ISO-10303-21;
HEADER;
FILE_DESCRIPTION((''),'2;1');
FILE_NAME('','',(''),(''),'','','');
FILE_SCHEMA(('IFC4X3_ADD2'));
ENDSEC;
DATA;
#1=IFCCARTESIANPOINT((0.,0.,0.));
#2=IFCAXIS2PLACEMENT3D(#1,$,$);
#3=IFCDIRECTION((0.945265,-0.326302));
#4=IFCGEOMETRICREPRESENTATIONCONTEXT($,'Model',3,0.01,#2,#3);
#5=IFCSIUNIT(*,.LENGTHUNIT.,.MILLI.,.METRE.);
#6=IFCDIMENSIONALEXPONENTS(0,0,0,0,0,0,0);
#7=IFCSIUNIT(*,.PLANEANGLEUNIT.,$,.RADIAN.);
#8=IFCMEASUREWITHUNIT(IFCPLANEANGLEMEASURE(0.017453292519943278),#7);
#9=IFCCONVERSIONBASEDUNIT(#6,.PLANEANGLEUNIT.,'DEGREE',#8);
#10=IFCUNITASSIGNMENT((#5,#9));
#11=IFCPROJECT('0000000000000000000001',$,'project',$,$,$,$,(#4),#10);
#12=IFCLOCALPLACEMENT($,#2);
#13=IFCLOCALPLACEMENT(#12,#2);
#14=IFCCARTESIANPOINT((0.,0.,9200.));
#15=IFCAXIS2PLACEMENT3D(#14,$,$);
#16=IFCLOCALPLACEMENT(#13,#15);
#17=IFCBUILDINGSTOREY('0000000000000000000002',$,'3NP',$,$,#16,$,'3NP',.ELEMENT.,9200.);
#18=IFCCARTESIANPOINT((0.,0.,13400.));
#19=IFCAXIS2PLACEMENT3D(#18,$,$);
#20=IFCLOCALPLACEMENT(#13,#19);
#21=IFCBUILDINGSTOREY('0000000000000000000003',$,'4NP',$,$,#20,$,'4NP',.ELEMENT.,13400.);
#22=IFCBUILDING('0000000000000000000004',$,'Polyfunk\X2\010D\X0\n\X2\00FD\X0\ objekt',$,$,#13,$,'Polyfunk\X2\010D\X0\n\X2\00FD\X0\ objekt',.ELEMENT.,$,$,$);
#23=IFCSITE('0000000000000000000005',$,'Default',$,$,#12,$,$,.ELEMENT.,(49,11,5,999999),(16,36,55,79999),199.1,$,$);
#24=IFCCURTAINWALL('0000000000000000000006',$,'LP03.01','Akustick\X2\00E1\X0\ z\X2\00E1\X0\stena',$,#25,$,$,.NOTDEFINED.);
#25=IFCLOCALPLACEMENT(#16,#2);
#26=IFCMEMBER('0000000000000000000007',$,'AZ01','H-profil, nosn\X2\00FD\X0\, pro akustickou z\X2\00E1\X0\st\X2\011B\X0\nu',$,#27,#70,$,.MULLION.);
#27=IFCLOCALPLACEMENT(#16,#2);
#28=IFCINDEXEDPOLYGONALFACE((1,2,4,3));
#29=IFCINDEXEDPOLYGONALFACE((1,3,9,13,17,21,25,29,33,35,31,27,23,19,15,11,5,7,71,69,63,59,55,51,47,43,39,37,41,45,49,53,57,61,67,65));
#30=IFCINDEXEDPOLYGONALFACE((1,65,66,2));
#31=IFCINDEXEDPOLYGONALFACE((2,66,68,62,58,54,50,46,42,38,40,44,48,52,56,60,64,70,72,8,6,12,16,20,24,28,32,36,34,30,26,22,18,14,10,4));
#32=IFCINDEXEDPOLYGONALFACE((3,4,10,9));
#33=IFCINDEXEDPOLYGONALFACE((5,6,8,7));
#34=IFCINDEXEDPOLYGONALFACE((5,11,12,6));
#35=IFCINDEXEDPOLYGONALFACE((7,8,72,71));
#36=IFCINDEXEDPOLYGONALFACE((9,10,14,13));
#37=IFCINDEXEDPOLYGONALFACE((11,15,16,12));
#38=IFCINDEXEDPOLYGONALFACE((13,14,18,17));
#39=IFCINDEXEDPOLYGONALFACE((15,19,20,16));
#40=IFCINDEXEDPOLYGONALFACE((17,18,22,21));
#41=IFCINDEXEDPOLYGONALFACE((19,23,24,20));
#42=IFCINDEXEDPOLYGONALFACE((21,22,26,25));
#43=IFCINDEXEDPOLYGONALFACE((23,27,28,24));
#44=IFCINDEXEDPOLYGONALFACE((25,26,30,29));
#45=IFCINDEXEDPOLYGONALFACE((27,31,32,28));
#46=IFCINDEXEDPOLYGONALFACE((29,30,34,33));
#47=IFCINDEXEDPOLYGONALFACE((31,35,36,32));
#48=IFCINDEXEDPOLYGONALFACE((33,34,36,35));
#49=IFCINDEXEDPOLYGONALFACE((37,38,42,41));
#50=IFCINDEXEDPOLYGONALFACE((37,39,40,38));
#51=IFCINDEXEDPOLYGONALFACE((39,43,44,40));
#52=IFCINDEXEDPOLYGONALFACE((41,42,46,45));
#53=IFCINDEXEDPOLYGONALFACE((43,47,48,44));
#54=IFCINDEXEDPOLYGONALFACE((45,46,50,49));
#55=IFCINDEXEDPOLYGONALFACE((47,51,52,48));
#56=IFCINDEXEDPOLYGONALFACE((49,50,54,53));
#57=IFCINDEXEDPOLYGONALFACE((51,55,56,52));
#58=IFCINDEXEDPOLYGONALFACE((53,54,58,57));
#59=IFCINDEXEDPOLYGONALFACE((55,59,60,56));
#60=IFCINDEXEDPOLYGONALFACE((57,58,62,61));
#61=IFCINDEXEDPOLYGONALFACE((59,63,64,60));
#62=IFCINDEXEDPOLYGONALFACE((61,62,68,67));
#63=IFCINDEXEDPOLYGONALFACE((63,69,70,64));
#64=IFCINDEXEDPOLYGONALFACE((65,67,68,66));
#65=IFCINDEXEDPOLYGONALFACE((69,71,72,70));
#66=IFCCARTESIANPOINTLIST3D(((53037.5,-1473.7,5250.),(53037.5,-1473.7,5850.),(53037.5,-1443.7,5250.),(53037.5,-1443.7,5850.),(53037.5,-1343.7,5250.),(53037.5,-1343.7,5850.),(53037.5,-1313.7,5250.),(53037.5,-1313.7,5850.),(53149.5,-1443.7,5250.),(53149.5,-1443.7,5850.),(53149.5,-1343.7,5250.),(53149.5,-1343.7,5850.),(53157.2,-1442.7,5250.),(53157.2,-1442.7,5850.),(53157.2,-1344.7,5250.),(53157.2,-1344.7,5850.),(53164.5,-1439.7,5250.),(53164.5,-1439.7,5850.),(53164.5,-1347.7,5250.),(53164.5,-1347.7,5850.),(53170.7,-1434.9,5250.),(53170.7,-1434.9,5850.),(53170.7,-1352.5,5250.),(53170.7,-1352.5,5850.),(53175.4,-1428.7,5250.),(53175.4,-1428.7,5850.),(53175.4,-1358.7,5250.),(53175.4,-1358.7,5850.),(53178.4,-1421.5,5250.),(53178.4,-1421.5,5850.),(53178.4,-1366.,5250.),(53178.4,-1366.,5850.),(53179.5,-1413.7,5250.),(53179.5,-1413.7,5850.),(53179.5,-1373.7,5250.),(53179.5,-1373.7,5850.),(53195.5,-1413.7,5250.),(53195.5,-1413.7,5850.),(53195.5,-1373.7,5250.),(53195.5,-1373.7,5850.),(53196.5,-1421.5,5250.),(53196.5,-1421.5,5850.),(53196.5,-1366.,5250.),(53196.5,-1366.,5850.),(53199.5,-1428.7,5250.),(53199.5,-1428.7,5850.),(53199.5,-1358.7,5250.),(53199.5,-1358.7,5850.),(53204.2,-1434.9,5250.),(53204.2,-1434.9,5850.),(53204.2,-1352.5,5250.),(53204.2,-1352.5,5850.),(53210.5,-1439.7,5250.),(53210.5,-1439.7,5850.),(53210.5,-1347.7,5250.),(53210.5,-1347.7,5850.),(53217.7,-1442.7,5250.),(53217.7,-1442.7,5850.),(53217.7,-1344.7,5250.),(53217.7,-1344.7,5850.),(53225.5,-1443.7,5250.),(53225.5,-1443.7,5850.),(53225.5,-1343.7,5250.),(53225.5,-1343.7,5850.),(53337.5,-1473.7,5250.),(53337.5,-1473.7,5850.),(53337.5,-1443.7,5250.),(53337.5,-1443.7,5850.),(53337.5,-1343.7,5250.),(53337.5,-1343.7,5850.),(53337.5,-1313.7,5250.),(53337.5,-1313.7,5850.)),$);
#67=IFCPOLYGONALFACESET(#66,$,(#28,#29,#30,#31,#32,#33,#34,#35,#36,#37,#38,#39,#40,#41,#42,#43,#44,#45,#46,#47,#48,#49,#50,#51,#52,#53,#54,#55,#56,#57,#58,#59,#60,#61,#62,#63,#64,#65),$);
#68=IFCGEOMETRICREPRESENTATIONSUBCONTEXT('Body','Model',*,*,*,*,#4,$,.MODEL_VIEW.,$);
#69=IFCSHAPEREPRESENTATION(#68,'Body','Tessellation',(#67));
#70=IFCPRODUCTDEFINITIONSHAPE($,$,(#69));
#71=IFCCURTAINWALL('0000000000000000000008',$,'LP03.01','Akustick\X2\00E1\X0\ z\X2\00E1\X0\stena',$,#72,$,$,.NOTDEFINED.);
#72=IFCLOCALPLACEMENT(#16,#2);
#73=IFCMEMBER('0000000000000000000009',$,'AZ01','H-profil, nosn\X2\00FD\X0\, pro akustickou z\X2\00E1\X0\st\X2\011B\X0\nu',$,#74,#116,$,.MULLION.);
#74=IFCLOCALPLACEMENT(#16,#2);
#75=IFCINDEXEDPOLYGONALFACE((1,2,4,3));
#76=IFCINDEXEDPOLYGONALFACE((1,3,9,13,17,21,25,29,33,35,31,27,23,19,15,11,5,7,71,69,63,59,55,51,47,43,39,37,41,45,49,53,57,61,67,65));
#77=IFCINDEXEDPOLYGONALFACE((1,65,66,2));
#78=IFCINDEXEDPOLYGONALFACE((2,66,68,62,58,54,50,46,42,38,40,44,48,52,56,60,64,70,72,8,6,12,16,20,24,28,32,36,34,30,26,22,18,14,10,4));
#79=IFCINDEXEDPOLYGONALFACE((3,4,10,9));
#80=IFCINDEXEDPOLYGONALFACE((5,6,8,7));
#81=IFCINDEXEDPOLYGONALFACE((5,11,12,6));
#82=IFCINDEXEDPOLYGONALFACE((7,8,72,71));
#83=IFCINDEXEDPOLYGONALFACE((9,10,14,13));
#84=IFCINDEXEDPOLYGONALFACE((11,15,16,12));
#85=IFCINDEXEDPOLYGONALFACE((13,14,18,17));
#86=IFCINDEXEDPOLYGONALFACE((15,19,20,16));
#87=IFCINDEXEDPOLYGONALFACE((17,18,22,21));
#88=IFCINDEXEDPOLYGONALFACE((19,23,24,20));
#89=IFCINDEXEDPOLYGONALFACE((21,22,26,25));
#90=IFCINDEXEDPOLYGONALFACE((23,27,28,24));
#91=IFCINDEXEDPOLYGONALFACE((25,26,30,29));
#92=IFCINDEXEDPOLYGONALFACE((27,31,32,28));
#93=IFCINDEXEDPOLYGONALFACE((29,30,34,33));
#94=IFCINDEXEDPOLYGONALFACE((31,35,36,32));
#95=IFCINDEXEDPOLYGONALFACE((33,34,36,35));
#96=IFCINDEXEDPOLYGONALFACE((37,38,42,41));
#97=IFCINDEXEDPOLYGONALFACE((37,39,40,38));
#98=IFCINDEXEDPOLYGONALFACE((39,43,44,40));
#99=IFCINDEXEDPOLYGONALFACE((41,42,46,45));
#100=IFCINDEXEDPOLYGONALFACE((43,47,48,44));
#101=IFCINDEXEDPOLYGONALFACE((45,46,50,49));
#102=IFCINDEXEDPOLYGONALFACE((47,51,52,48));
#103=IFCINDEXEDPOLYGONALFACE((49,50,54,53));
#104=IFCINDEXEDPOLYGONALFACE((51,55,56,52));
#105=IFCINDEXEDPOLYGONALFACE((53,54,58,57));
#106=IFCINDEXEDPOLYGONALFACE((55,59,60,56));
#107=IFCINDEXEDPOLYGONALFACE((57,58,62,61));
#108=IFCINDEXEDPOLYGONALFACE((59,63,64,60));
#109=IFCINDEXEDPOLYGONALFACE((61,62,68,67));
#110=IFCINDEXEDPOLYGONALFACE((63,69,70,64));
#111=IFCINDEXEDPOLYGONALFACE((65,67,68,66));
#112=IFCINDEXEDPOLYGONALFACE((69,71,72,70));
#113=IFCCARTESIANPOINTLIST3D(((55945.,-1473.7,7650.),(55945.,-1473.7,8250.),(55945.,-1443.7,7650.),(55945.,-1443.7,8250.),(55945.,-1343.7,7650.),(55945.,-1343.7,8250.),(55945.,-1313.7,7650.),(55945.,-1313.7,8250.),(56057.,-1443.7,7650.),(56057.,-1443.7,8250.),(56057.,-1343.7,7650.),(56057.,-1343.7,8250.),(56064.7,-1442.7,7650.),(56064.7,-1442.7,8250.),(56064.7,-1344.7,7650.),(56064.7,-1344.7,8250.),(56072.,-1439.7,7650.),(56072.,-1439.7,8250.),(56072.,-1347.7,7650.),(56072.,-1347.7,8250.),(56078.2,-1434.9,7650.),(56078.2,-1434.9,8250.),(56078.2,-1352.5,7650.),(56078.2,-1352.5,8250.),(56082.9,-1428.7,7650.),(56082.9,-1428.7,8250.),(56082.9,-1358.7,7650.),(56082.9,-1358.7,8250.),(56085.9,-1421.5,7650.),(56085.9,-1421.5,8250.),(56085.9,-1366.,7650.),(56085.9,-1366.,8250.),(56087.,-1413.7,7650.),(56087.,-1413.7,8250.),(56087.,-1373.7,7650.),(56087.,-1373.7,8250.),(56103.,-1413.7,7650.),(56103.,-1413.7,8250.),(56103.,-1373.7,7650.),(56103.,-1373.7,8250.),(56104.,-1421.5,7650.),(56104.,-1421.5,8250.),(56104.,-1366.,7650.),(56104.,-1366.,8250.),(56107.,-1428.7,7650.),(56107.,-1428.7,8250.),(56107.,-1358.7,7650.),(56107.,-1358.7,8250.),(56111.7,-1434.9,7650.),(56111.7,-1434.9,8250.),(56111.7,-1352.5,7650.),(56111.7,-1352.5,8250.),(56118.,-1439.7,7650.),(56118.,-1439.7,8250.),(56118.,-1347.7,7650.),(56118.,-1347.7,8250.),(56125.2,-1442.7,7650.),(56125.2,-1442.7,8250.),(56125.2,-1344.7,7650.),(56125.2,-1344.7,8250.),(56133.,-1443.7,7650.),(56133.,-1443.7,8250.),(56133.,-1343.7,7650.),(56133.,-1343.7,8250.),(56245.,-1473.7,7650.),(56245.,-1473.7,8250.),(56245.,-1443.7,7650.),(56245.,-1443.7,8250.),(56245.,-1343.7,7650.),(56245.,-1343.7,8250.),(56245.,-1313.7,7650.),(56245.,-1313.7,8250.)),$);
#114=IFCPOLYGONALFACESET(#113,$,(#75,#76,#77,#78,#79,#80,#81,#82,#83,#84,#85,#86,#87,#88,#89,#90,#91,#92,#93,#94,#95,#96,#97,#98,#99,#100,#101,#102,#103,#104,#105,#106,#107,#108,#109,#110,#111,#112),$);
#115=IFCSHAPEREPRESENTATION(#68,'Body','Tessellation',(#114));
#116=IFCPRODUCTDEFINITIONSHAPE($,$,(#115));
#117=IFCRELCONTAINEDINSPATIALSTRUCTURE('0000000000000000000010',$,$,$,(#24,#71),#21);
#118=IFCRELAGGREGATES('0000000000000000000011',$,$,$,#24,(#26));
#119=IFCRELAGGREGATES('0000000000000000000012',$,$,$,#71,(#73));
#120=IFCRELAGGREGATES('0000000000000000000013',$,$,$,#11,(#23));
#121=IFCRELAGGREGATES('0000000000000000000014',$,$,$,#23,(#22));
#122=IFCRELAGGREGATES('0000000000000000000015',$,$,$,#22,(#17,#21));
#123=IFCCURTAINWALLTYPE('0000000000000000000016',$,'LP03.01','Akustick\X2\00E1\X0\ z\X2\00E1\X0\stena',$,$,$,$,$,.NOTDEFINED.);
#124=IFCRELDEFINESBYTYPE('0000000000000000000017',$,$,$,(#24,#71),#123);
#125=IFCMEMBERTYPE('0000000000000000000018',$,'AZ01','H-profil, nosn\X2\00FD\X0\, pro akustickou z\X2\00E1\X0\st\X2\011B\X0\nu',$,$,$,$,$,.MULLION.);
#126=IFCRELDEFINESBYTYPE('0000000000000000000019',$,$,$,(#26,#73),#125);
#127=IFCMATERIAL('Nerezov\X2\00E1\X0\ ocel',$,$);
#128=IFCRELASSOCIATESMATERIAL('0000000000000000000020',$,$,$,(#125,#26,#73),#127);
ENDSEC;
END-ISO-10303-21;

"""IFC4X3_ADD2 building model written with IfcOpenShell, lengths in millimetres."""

from ifc_helpers import new_model, entity, si_unit, converted_unit, direction, frame, frame_2d, origin, place, context, subcontext, project, spatial, polyline, circle_curve, parameter, trimmed, segment, composite_curve, outline, extrude, source, transform, mapped, material, material_profile, profile_set, profile_usage, type_object, element, aggregate, save


model = new_model("IFC4X3_ADD2")

# Units and contexts
model_context = context("Model", 3, precision=0.01, world=origin(), true_north=direction((0.945265, -0.326302)))
body_context = subcontext(model_context, "Body", "Model", "MODEL_VIEW")
ifc_project = project(units=[si_unit("LENGTHUNIT", "METRE", prefix="MILLI"), converted_unit("PLANEANGLEUNIT", "DEGREE", entity("IfcPlaneAngleMeasure", 0.017453292519943278), si_unit("PLANEANGLEUNIT", "RADIAN"), dimensions=[0, 0, 0, 0, 0, 0, 0])], contexts=[model_context])

# Site, building, storey
site_placement = place(None, origin())
site = spatial("IfcSite", under=ifc_project, at=site_placement, Name="Default", CompositionType="ELEMENT", RefLatitude=(49, 11, 5, 999999), RefLongitude=(16, 36, 55, 79999), RefElevation=199.1)
building_placement = place(site_placement, origin())
building = spatial("IfcBuilding", under=site, at=building_placement, Name="Polyfunkčný objekt", LongName="Polyfunkčný objekt", CompositionType="ELEMENT")
storey_1_placement = place(building_placement, frame((0.0, 0.0, 9200.0)))
storey_1 = spatial("IfcBuildingStorey", under=building, at=storey_1_placement, Name="3NP", LongName="3NP", CompositionType="ELEMENT", Elevation=9200.0)

# Shared definitions
storey_2_placement = place(building_placement, frame((0.0, 0.0, 13400.0)))
storey_2 = spatial("IfcBuildingStorey", under=building, at=storey_2_placement, Name="4NP", LongName="4NP", CompositionType="ELEMENT", Elevation=13400.0)

# Curtain walls, members
curtain_wall_type_1 = type_object("IfcCurtainWallType", Name="LP03.01", Description="Akustická zástena", PredefinedType="NOTDEFINED")
curtain_wall_1_placement = place(storey_2_placement, frame((0.0, 0.0, -13400.0)))
curtain_wall_1 = element("IfcCurtainWall", 1, at=curtain_wall_1_placement, inside=storey_2, type_object=curtain_wall_type_1, Name="LP03.01", Description="Akustická zástena", PredefinedType="NOTDEFINED")
ifc_material_1 = material(Name="Nerezová ocel")
ifc_material_profile_1 = material_profile(ifc_material_1, outline(composite_curve([segment(polyline([(50.0, -150.0), (80.0, -150.0)]), True, "CONTINUOUS"), segment(polyline([(80.0, -150.0), (80.0, 150.0)]), True, "CONTINUOUS"), segment(polyline([(80.0, 150.0), (50.0, 150.0)]), True, "CONTINUOUS"), segment(polyline([(50.0, 150.0), (50.0, 38.0)]), True, "CONTINUOUS"), segment(trimmed(circle_curve(frame_2d((20.0, 38.0), x_axis=(0.0, 1.0)), 30.0), [parameter(180.0)], [parameter(270.0)], True, "PARAMETER"), False, "CONTINUOUS"), segment(polyline([(20.0, 8.0), (-20.0, 8.0)]), True, "CONTINUOUS"), segment(trimmed(circle_curve(frame_2d((-20.0, 38.0), x_axis=(0.0, 1.0)), 30.0), [parameter(90.0)], [parameter(180.0)], True, "PARAMETER"), False, "CONTINUOUS"), segment(polyline([(-50.0, 38.0), (-50.0, 150.0)]), True, "CONTINUOUS"), segment(polyline([(-50.0, 150.0), (-80.0, 150.0)]), True, "CONTINUOUS"), segment(polyline([(-80.0, 150.0), (-80.0, -150.0)]), True, "CONTINUOUS"), segment(polyline([(-80.0, -150.0), (-50.0, -150.0)]), True, "CONTINUOUS"), segment(polyline([(-50.0, -150.0), (-50.0, -38.0)]), True, "CONTINUOUS"), segment(trimmed(circle_curve(frame_2d((-20.0, -38.0), x_axis=(0.0, 1.0)), 30.0), [parameter(0.0)], [parameter(90.0)], True, "PARAMETER"), False, "CONTINUOUS"), segment(polyline([(-20.0, -8.0), (20.0, -8.0)]), True, "CONTINUOUS"), segment(trimmed(circle_curve(frame_2d((20.0, -38.0), x_axis=(0.0, 1.0)), 30.0), [parameter(270.0)], [parameter(0.0)], True, "PARAMETER"), False, "CONTINUOUS"), segment(polyline([(50.0, -38.0), (50.0, -150.0)]), True, "CONTINUOUS")], self_intersect=False)), Name="Profil zástena")
ifc_profile_set_1 = profile_set([ifc_material_profile_1], Name="Profil zástena")
ifc_profile_usage_1 = profile_usage(ifc_profile_set_1)
member_type_1 = type_object("IfcMemberType", Name="AZ01", Description="H-profil, nosný, pro akustickou zástěnu", PredefinedType="MULLION", material=ifc_profile_set_1)
shared_shape_1 = source(origin(), body_context, "Body", "SweptSolid", [
    extrude(outline(composite_curve([segment(polyline([(50.0, -150.0), (80.0, -150.0)]), True, "CONTINUOUS"), segment(polyline([(80.0, -150.0), (80.0, 150.0)]), True, "CONTINUOUS"), segment(polyline([(80.0, 150.0), (50.0, 150.0)]), True, "CONTINUOUS"), segment(polyline([(50.0, 150.0), (50.0, 38.0)]), True, "CONTINUOUS"), segment(trimmed(circle_curve(frame_2d((20.0, 38.0), x_axis=(0.0, 1.0)), 30.0), [parameter(180.0)], [parameter(270.0)], True, "PARAMETER"), False, "CONTINUOUS"), segment(polyline([(20.0, 8.0), (-20.0, 8.0)]), True, "CONTINUOUS"), segment(trimmed(circle_curve(frame_2d((-20.0, 38.0), x_axis=(0.0, 1.0)), 30.0), [parameter(90.0)], [parameter(180.0)], True, "PARAMETER"), False, "CONTINUOUS"), segment(polyline([(-50.0, 38.0), (-50.0, 150.0)]), True, "CONTINUOUS"), segment(polyline([(-50.0, 150.0), (-80.0, 150.0)]), True, "CONTINUOUS"), segment(polyline([(-80.0, 150.0), (-80.0, -150.0)]), True, "CONTINUOUS"), segment(polyline([(-80.0, -150.0), (-50.0, -150.0)]), True, "CONTINUOUS"), segment(polyline([(-50.0, -150.0), (-50.0, -38.0)]), True, "CONTINUOUS"), segment(trimmed(circle_curve(frame_2d((-20.0, -38.0), x_axis=(0.0, 1.0)), 30.0), [parameter(0.0)], [parameter(90.0)], True, "PARAMETER"), False, "CONTINUOUS"), segment(polyline([(-20.0, -8.0), (20.0, -8.0)]), True, "CONTINUOUS"), segment(trimmed(circle_curve(frame_2d((20.0, -38.0), x_axis=(0.0, 1.0)), 30.0), [parameter(270.0)], [parameter(0.0)], True, "PARAMETER"), False, "CONTINUOUS"), segment(polyline([(50.0, -38.0), (50.0, -150.0)]), True, "CONTINUOUS")], self_intersect=False)), frame((0.0, 0.0, -600.0), z_axis=(0.0, 0.0, 1.0), x_axis=(0.0, -1.0, 0.0)), (0.0, 0.0, 1.0), 600.0),
])
member_1_placement = place(curtain_wall_1_placement, frame((53187.5, -1393.7, 14450.0), z_axis=(0.0, 0.0, -1.0), x_axis=(1.0, 0.0, 0.0)))
member_1 = element("IfcMember", 2, at=member_1_placement, type_object=member_type_1, material=ifc_profile_usage_1, Name="AZ01", Description="H-profil, nosný, pro akustickou zástěnu", PredefinedType="MULLION", context=body_context, shape_type="MappedRepresentation", body=[
    mapped(shared_shape_1, transform((0.0, 0.0, 0.0), scale=1.0)),
])
aggregate(curtain_wall_1, [member_1])
curtain_wall_2_placement = place(storey_2_placement, frame((0.0, 0.0, -13400.0)))
curtain_wall_2 = element("IfcCurtainWall", 3, at=curtain_wall_2_placement, inside=storey_2, type_object=curtain_wall_type_1, Name="LP03.01", Description="Akustická zástena", PredefinedType="NOTDEFINED")
shared_shape_2 = source(origin(), body_context, "Body", "SweptSolid", [
    extrude(outline(composite_curve([segment(polyline([(50.0, -150.0), (80.0, -150.0)]), True, "CONTINUOUS"), segment(polyline([(80.0, -150.0), (80.0, 150.0)]), True, "CONTINUOUS"), segment(polyline([(80.0, 150.0), (50.0, 150.0)]), True, "CONTINUOUS"), segment(polyline([(50.0, 150.0), (50.0, 38.0)]), True, "CONTINUOUS"), segment(trimmed(circle_curve(frame_2d((20.0, 38.0), x_axis=(0.0, 1.0)), 30.0), [parameter(180.0)], [parameter(270.0)], True, "PARAMETER"), False, "CONTINUOUS"), segment(polyline([(20.0, 8.0), (-20.0, 8.0)]), True, "CONTINUOUS"), segment(trimmed(circle_curve(frame_2d((-20.0, 38.0), x_axis=(0.0, 1.0)), 30.0), [parameter(90.0)], [parameter(180.0)], True, "PARAMETER"), False, "CONTINUOUS"), segment(polyline([(-50.0, 38.0), (-50.0, 150.0)]), True, "CONTINUOUS"), segment(polyline([(-50.0, 150.0), (-80.0, 150.0)]), True, "CONTINUOUS"), segment(polyline([(-80.0, 150.0), (-80.0, -150.0)]), True, "CONTINUOUS"), segment(polyline([(-80.0, -150.0), (-50.0, -150.0)]), True, "CONTINUOUS"), segment(polyline([(-50.0, -150.0), (-50.0, -38.0)]), True, "CONTINUOUS"), segment(trimmed(circle_curve(frame_2d((-20.0, -38.0), x_axis=(0.0, 1.0)), 30.0), [parameter(0.0)], [parameter(90.0)], True, "PARAMETER"), False, "CONTINUOUS"), segment(polyline([(-20.0, -8.0), (20.0, -8.0)]), True, "CONTINUOUS"), segment(trimmed(circle_curve(frame_2d((20.0, -38.0), x_axis=(0.0, 1.0)), 30.0), [parameter(270.0)], [parameter(0.0)], True, "PARAMETER"), False, "CONTINUOUS"), segment(polyline([(50.0, -38.0), (50.0, -150.0)]), True, "CONTINUOUS")], self_intersect=False)), frame((-150.0, 0.0, -600.0), z_axis=(0.0, 0.0, 1.0), x_axis=(0.0, -1.0, 0.0)), (0.0, 0.0, 1.0), 600.0),
])
member_2_placement = place(curtain_wall_2_placement, frame((56245.0, -1393.7, 16850.0), z_axis=(0.0, 0.0, -1.0), x_axis=(1.0, 0.0, 0.0)))
member_2 = element("IfcMember", 4, at=member_2_placement, type_object=member_type_1, material=ifc_profile_usage_1, Name="AZ01", Description="H-profil, nosný, pro akustickou zástěnu", PredefinedType="MULLION", context=body_context, shape_type="MappedRepresentation", body=[
    mapped(shared_shape_2, transform((0.0, 0.0, 0.0), scale=1.0)),
])
aggregate(curtain_wall_2, [member_2])

save(model, "model.ifc")
